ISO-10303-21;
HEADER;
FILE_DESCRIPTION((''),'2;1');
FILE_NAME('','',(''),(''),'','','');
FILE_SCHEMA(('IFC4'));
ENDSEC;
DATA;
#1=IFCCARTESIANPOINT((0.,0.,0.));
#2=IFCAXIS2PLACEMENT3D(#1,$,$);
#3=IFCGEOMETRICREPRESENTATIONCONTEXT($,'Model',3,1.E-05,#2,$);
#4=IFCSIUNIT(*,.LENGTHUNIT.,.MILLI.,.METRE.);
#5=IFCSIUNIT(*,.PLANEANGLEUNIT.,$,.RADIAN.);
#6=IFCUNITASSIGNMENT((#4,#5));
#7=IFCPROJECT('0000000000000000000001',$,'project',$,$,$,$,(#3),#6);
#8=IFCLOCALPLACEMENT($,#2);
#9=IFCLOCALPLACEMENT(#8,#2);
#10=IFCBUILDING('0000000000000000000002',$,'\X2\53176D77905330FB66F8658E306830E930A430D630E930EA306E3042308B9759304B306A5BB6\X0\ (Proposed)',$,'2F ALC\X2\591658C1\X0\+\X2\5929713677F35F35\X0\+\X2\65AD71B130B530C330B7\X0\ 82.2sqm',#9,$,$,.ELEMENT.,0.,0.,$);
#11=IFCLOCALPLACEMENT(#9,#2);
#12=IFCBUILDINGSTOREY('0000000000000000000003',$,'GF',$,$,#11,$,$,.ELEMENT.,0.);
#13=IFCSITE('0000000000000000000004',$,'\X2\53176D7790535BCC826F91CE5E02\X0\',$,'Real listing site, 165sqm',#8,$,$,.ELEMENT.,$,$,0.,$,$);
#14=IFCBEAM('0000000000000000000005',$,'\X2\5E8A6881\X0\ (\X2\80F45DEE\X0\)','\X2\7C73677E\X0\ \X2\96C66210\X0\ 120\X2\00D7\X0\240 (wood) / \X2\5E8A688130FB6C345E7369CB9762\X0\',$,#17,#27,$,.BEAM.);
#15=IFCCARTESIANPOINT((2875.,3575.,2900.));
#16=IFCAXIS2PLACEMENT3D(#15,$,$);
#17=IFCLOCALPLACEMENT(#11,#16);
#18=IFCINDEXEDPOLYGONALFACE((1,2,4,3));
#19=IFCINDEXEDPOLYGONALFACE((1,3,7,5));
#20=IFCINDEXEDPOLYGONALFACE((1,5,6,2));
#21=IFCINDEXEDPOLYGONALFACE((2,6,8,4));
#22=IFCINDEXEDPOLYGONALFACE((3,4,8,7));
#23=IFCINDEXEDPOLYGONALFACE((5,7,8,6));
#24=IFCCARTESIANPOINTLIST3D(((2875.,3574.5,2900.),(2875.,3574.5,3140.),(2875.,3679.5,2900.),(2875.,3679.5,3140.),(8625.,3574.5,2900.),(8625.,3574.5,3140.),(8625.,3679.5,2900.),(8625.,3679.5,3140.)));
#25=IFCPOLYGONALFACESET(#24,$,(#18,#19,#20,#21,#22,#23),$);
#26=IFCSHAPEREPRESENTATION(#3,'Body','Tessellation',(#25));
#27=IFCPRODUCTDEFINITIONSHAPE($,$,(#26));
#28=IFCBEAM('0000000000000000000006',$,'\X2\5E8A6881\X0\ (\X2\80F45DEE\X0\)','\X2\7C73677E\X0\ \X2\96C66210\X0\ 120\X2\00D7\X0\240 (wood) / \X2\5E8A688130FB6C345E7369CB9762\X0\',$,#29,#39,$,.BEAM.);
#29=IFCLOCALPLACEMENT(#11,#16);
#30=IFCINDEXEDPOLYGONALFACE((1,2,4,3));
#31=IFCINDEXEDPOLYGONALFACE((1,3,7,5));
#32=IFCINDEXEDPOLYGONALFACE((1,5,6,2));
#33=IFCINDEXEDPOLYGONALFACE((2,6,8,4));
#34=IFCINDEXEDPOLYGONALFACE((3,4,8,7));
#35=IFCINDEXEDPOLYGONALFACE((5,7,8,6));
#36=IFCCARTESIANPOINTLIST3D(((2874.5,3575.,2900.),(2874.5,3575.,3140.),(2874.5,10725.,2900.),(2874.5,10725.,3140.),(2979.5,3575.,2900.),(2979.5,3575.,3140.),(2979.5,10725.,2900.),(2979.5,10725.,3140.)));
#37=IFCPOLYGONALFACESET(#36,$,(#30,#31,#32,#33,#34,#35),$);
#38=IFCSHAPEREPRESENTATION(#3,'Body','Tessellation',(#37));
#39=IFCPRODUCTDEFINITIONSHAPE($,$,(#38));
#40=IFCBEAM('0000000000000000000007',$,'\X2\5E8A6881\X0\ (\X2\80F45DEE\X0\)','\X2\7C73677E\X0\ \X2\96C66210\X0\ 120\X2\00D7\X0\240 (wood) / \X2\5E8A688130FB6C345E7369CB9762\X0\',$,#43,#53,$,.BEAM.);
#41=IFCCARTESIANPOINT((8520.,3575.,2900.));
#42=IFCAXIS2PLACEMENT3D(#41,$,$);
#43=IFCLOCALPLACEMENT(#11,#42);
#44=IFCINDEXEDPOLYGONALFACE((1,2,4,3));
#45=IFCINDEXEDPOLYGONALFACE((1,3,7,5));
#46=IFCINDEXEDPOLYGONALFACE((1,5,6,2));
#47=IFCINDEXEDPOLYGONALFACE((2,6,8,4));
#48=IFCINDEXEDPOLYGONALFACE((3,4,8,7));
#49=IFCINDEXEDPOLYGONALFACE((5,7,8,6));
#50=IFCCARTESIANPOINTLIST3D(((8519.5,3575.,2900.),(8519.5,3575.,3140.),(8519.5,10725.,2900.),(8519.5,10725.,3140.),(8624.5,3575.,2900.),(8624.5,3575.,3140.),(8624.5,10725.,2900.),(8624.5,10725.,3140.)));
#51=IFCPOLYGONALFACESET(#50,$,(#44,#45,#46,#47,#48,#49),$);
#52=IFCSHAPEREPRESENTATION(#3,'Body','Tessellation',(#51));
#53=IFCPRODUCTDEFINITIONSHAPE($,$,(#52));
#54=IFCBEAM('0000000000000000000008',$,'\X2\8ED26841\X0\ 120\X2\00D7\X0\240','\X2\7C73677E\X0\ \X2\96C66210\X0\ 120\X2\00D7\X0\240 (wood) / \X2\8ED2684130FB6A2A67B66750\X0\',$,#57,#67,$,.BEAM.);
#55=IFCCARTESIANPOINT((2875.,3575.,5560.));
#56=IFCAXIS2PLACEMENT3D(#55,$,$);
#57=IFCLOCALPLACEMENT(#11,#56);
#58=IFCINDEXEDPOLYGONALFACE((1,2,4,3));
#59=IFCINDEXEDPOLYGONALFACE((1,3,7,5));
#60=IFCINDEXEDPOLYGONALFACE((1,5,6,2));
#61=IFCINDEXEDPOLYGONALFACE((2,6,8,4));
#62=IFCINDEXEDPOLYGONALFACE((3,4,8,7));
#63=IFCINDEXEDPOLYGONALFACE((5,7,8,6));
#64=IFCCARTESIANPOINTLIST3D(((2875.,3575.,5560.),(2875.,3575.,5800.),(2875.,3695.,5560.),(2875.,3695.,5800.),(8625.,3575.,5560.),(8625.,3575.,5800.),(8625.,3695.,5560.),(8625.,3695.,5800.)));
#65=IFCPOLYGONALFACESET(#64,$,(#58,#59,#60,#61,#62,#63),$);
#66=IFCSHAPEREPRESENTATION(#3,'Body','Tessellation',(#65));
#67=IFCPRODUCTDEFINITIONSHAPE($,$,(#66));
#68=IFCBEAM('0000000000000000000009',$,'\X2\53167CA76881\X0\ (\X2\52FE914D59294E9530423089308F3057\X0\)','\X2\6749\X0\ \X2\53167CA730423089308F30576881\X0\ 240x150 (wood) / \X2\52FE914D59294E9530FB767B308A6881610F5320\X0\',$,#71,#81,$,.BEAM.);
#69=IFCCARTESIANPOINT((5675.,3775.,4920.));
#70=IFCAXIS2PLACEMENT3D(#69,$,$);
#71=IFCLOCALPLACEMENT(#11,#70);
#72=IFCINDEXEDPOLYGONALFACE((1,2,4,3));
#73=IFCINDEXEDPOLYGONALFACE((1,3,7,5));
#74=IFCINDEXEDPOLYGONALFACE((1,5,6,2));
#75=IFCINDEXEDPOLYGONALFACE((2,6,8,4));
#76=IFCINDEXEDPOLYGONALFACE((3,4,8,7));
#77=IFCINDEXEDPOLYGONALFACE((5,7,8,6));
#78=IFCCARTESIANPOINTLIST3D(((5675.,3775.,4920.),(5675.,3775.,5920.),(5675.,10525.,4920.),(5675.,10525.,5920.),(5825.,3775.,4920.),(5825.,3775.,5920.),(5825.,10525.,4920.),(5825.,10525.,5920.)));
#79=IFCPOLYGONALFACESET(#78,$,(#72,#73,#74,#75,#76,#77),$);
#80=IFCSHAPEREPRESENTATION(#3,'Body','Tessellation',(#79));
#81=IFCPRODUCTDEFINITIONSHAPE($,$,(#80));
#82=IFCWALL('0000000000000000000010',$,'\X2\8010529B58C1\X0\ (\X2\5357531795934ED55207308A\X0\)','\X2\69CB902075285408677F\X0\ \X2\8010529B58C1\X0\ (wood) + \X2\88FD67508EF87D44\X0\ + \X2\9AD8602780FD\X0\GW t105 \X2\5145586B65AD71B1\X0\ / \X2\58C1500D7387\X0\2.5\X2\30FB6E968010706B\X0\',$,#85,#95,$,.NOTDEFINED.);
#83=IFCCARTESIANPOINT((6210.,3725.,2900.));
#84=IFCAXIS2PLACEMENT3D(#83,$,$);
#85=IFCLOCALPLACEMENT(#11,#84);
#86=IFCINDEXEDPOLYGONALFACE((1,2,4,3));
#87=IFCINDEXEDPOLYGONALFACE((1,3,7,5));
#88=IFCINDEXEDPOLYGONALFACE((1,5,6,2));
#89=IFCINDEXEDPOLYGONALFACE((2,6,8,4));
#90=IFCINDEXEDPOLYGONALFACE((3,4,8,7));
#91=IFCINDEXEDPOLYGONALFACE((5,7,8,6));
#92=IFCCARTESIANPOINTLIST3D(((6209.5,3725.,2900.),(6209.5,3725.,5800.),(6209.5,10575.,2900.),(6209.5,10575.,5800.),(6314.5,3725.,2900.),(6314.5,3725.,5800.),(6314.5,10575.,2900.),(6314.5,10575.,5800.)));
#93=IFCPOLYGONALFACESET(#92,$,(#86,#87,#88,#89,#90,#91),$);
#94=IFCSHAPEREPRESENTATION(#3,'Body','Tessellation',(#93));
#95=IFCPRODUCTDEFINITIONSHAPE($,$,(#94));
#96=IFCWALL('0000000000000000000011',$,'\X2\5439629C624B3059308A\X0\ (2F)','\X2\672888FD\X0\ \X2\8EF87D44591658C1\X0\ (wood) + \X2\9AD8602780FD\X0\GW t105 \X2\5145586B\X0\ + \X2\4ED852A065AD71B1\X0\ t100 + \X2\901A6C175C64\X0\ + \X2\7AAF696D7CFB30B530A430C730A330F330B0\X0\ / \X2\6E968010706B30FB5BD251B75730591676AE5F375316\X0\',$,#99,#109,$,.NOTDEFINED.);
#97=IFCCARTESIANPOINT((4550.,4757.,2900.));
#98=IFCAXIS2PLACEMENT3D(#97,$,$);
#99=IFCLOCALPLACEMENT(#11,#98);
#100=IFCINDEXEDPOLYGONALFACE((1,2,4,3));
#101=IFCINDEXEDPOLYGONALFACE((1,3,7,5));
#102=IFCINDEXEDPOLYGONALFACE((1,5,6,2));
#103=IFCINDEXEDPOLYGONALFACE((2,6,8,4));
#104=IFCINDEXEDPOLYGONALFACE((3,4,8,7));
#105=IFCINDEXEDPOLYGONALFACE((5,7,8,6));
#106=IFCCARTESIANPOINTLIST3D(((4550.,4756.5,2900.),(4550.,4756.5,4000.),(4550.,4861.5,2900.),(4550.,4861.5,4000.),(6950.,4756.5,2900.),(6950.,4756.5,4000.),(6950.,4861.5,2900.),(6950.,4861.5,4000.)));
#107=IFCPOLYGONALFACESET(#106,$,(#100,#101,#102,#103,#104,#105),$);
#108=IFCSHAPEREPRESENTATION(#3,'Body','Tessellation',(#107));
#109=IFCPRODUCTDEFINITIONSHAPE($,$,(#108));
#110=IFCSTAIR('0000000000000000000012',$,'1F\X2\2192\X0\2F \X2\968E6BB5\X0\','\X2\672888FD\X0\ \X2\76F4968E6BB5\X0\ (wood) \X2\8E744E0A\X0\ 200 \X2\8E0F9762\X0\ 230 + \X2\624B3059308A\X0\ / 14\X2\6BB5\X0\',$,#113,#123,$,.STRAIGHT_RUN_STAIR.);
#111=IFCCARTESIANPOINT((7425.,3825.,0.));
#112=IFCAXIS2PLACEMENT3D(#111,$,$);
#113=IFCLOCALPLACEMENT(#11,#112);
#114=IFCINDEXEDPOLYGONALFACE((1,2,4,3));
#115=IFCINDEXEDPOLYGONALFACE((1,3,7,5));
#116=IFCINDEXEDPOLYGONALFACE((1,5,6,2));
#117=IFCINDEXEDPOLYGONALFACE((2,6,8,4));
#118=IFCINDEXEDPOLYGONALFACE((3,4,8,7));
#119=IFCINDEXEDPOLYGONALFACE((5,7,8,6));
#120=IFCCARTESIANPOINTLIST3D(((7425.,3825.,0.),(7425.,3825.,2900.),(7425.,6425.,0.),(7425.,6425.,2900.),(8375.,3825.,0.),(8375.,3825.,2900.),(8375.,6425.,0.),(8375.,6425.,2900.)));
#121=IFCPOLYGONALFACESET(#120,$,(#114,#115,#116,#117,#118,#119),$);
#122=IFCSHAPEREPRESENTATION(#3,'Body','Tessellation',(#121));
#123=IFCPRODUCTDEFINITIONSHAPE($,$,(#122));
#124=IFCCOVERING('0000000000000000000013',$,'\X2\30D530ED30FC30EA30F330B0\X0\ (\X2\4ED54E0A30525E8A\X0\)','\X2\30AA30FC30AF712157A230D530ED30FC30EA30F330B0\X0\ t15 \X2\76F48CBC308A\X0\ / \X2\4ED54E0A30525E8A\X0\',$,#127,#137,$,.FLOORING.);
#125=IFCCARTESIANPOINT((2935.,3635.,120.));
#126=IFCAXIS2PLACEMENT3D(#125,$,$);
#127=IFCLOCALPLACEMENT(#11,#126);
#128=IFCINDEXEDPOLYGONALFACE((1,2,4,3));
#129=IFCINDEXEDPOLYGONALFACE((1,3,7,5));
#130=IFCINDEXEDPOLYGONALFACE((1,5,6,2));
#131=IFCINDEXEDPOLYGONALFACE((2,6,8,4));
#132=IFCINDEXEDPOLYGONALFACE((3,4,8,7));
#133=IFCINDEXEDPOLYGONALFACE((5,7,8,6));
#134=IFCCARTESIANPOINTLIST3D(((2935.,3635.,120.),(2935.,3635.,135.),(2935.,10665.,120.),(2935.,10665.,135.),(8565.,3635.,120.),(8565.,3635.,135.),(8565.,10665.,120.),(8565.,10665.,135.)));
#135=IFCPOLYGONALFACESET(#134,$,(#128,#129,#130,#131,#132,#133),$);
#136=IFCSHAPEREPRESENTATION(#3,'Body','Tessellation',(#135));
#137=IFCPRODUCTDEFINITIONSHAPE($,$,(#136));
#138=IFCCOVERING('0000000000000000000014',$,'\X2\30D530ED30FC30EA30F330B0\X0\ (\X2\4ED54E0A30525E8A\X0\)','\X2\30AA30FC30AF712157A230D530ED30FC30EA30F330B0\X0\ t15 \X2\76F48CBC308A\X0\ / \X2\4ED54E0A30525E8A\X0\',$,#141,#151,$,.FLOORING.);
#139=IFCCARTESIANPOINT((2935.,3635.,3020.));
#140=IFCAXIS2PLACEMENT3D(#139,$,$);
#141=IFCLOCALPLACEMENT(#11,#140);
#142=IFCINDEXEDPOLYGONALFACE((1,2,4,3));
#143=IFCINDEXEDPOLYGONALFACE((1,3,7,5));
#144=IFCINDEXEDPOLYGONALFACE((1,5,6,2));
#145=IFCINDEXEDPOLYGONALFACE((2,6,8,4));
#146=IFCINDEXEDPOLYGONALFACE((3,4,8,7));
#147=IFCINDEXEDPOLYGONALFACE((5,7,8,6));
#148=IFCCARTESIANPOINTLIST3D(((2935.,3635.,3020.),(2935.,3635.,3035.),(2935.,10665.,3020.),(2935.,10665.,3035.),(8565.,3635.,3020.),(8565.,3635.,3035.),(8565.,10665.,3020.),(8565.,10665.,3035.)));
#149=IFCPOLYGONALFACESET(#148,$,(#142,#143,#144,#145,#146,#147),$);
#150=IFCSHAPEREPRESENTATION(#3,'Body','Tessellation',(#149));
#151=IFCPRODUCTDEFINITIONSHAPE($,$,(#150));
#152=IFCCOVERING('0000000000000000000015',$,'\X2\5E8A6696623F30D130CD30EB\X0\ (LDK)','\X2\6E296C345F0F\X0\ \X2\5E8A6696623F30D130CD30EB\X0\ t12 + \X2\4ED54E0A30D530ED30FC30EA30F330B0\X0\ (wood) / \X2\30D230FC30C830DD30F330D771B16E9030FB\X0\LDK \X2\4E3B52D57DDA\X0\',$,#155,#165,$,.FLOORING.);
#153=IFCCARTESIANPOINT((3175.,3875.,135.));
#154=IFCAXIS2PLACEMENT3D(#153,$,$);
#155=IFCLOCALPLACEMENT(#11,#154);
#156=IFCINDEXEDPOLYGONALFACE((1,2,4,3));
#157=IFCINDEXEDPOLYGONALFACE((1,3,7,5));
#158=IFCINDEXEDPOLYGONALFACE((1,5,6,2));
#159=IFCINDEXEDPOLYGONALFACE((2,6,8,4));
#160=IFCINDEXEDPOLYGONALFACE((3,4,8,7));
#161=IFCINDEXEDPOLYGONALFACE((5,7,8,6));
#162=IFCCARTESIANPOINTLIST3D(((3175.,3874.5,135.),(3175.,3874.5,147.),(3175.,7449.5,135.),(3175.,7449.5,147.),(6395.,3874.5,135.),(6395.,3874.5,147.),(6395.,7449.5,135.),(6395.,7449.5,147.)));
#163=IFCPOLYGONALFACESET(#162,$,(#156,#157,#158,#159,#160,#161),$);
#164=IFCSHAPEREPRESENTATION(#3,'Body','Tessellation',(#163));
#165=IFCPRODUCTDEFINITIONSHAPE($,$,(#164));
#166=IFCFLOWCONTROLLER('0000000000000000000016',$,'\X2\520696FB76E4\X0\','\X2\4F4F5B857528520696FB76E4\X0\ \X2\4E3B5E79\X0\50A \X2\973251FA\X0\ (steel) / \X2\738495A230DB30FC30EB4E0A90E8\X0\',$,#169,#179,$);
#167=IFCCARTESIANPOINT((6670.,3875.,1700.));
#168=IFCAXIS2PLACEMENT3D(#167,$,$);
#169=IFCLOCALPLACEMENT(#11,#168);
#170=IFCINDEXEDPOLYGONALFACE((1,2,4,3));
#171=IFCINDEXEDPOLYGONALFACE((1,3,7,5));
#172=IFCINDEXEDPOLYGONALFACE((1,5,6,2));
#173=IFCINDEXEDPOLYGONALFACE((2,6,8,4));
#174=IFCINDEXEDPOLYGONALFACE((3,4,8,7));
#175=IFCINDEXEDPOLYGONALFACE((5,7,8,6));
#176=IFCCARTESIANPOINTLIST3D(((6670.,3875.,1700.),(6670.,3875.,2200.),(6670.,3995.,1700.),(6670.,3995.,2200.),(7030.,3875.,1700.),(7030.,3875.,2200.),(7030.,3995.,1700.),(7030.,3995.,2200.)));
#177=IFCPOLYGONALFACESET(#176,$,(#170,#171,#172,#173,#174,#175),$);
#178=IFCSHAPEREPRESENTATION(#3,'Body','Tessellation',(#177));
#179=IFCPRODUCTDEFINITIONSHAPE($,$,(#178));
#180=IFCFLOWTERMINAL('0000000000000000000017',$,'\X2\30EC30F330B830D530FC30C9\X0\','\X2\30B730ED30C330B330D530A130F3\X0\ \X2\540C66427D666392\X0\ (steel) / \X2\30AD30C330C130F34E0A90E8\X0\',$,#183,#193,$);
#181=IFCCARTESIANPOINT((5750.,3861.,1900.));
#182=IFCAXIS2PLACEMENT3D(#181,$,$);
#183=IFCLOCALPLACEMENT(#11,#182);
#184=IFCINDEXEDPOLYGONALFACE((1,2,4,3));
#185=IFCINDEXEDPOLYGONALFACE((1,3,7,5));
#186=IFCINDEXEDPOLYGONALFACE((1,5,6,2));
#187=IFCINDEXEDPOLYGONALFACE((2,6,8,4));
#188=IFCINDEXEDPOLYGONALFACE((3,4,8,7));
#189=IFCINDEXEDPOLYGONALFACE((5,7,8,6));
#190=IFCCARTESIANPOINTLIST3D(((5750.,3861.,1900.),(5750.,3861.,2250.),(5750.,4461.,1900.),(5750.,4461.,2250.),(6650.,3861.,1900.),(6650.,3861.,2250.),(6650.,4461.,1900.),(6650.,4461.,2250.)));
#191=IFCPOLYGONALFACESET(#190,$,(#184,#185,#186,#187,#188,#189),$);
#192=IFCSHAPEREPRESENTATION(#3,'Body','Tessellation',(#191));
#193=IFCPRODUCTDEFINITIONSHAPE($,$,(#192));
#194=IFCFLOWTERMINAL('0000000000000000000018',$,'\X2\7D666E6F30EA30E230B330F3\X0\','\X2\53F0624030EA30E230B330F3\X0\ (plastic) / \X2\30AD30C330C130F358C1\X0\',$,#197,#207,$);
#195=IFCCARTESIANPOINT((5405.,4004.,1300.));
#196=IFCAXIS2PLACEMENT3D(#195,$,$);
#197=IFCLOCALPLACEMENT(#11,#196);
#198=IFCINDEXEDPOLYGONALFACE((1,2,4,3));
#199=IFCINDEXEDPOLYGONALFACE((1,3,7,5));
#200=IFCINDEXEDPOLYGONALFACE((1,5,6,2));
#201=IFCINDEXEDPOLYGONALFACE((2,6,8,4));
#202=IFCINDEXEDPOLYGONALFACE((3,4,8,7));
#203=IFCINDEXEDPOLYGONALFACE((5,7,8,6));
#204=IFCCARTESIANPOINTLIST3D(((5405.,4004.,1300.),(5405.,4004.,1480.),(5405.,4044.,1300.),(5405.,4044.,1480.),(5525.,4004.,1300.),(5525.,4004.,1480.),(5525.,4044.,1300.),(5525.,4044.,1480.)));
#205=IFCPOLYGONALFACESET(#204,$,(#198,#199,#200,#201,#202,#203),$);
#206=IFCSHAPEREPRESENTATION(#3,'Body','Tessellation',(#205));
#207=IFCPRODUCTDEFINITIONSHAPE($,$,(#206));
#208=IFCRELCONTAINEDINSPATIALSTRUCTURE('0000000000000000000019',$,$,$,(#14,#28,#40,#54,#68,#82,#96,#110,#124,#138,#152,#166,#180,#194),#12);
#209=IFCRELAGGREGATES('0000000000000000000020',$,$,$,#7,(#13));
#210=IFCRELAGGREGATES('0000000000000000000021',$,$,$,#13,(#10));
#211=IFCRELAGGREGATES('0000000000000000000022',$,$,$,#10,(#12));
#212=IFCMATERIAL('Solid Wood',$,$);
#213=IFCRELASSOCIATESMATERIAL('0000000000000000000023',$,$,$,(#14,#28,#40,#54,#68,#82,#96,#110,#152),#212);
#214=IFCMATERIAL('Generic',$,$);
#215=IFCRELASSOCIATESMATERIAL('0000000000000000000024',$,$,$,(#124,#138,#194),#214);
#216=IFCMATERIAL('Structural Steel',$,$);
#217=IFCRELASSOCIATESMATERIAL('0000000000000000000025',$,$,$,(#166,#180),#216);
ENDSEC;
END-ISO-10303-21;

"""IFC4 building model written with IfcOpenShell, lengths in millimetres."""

from ifc_helpers import new_model, si_unit, frame, frame_2d, origin, place, context, project, spatial, rectangle, extrude, material, element, save


model = new_model("IFC4")

# Units and contexts
model_context = context("Model", 3, precision=1e-05, world=origin())
ifc_project = project(units=[si_unit("LENGTHUNIT", "METRE", prefix="MILLI"), si_unit("PLANEANGLEUNIT", "RADIAN")], contexts=[model_context])

# Site, building, storey
site_placement = place(None, origin())
site = spatial("IfcSite", under=ifc_project, at=site_placement, Name="北海道富良野市", ObjectType="Real listing site, 165sqm", CompositionType="ELEMENT", RefElevation=0.0)
building_placement = place(site_placement, origin())
building = spatial("IfcBuilding", under=site, at=building_placement, Name="北海道・書斎とライブラリのある静かな家 (Proposed)", ObjectType="2F ALC外壁+天然石張+断熱サッシ 82.2sqm", CompositionType="ELEMENT", ElevationOfRefHeight=0.0, ElevationOfTerrain=0.0)
storey_placement = place(building_placement, origin())
storey = spatial("IfcBuildingStorey", under=building, at=storey_placement, Name="GF", CompositionType="ELEMENT", Elevation=0.0)

# Beams
ifc_material_1 = material(Name="Solid Wood")
beam_1_placement = place(storey_placement, frame((2875.0, 3575.0, 2900.0)))
element("IfcBeam", 1, at=beam_1_placement, inside=storey, material=ifc_material_1, Name="床梁 (胴差)", Description="米松 集成 120×240 (wood) / 床梁・水平構面", PredefinedType="BEAM", context=model_context, shape_type="SweptSolid", body=[
    extrude(rectangle(XDim=5750.0, YDim=105.0, at=frame_2d((2875.0, 52.0))), frame((2875.0, 3575.0, 2900.0)), (0.0, 0.0, 1.0), 240.0),
])
beam_2_placement = place(storey_placement, frame((2875.0, 3575.0, 2900.0)))
element("IfcBeam", 2, at=beam_2_placement, inside=storey, material=ifc_material_1, Name="床梁 (胴差)", Description="米松 集成 120×240 (wood) / 床梁・水平構面", PredefinedType="BEAM", context=model_context, shape_type="SweptSolid", body=[
    extrude(rectangle(XDim=105.0, YDim=7150.0, at=frame_2d((52.0, 3575.0))), frame((2875.0, 3575.0, 2900.0)), (0.0, 0.0, 1.0), 240.0),
])
beam_3_placement = place(storey_placement, frame((8520.0, 3575.0, 2900.0)))
element("IfcBeam", 3, at=beam_3_placement, inside=storey, material=ifc_material_1, Name="床梁 (胴差)", Description="米松 集成 120×240 (wood) / 床梁・水平構面", PredefinedType="BEAM", context=model_context, shape_type="SweptSolid", body=[
    extrude(rectangle(XDim=105.0, YDim=7150.0, at=frame_2d((52.0, 3575.0))), frame((8520.0, 3575.0, 2900.0)), (0.0, 0.0, 1.0), 240.0),
])
beam_4_placement = place(storey_placement, frame((2875.0, 3575.0, 5560.0)))
element("IfcBeam", 4, at=beam_4_placement, inside=storey, material=ifc_material_1, Name="軒桁 120×240", Description="米松 集成 120×240 (wood) / 軒桁・横架材", PredefinedType="BEAM", context=model_context, shape_type="SweptSolid", body=[
    extrude(rectangle(XDim=5750.0, YDim=120.0, at=frame_2d((2875.0, 60.0))), frame((2875.0, 3575.0, 5560.0)), (0.0, 0.0, 1.0), 240.0),
])
beam_5_placement = place(storey_placement, frame((5675.0, 3775.0, 4920.0)))
element("IfcBeam", 5, at=beam_5_placement, inside=storey, material=ifc_material_1, Name="化粧梁 (勾配天井あらわし)", Description="杉 化粧あらわし梁 240x150 (wood) / 勾配天井・登り梁意匠", PredefinedType="BEAM", context=model_context, shape_type="SweptSolid", body=[
    extrude(rectangle(XDim=150.0, YDim=6750.0, at=frame_2d((75.0, 3375.0))), frame((5675.0, 3775.0, 4920.0)), (0.0, 0.0, 1.0), 1000.0),
])

# Walls
wall_1_placement = place(storey_placement, frame((6210.0, 3725.0, 2900.0)))
element("IfcWall", 6, at=wall_1_placement, inside=storey, material=ifc_material_1, Name="耐力壁 (南北間仕切り)", Description="構造用合板 耐力壁 (wood) + 製材軸組 + 高性能GW t105 充填断熱 / 壁倍率2.5・準耐火", PredefinedType="NOTDEFINED", context=model_context, shape_type="SweptSolid", body=[
    extrude(rectangle(XDim=105.0, YDim=6850.0, at=frame_2d((52.0, 3425.0))), frame((6210.0, 3725.0, 2900.0)), (0.0, 0.0, 1.0), 2900.0),
])
wall_2_placement = place(storey_placement, frame((4550.0, 4757.0, 2900.0)))
element("IfcWall", 7, at=wall_2_placement, inside=storey, material=ifc_material_1, Name="吹抜手すり (2F)", Description="木製 軸組外壁 (wood) + 高性能GW t105 充填 + 付加断熱 t100 + 通気層 + 窯業系サイディング / 準耐火・寒冷地外皮強化", PredefinedType="NOTDEFINED", context=model_context, shape_type="SweptSolid", body=[
    extrude(rectangle(XDim=2400.0, YDim=105.0, at=frame_2d((1200.0, 52.0))), frame((4550.0, 4757.0, 2900.0)), (0.0, 0.0, 1.0), 1100.0),
])

# Stair
stair_placement = place(storey_placement, frame((7425.0, 3825.0, 0.0)))
element("IfcStair", 8, at=stair_placement, inside=storey, material=ifc_material_1, Name="1F→2F 階段", Description="木製 直階段 (wood) 蹴上 200 踏面 230 + 手すり / 14段", PredefinedType="STRAIGHT_RUN_STAIR", context=model_context, shape_type="SweptSolid", body=[
    extrude(rectangle(XDim=950.0, YDim=2600.0, at=frame_2d((475.0, 1300.0))), frame((7425.0, 3825.0, 0.0)), (0.0, 0.0, 1.0), 2900.0),
])

# Coverings
ifc_material_2 = material(Name="Generic")
covering_1_placement = place(storey_placement, frame((2935.0, 3635.0, 120.0)))
element("IfcCovering", 9, at=covering_1_placement, inside=storey, material=ifc_material_2, Name="フローリング (仕上げ床)", Description="オーク無垢フローリング t15 直貼り / 仕上げ床", PredefinedType="FLOORING", context=model_context, shape_type="SweptSolid", body=[
    extrude(rectangle(XDim=5630.0, YDim=7030.0, at=frame_2d((2815.0, 3515.0))), frame((2935.0, 3635.0, 120.0)), (0.0, 0.0, 1.0), 15.0),
])
covering_2_placement = place(storey_placement, frame((2935.0, 3635.0, 3020.0)))
element("IfcCovering", 10, at=covering_2_placement, inside=storey, material=ifc_material_2, Name="フローリング (仕上げ床)", Description="オーク無垢フローリング t15 直貼り / 仕上げ床", PredefinedType="FLOORING", context=model_context, shape_type="SweptSolid", body=[
    extrude(rectangle(XDim=5630.0, YDim=7030.0, at=frame_2d((2815.0, 3515.0))), frame((2935.0, 3635.0, 3020.0)), (0.0, 0.0, 1.0), 15.0),
])
covering_3_placement = place(storey_placement, frame((3175.0, 3875.0, 135.0)))
element("IfcCovering", 11, at=covering_3_placement, inside=storey, material=ifc_material_1, Name="床暖房パネル (LDK)", Description="温水式 床暖房パネル t12 + 仕上フローリング (wood) / ヒートポンプ熱源・LDK 主動線", PredefinedType="FLOORING", context=model_context, shape_type="SweptSolid", body=[
    extrude(rectangle(XDim=3220.0, YDim=3575.0, at=frame_2d((1610.0, 1787.0))), frame((3175.0, 3875.0, 135.0)), (0.0, 0.0, 1.0), 12.0),
])

# Flow controller
ifc_material_3 = material(Name="Structural Steel")
flow_controller_placement = place(storey_placement, frame((6670.0, 3875.0, 1700.0)))
element("IfcFlowController", 12, at=flow_controller_placement, inside=storey, material=ifc_material_3, Name="分電盤", Description="住宅用分電盤 主幹50A 露出 (steel) / 玄関ホール上部", context=model_context, shape_type="SweptSolid", body=[
    extrude(rectangle(XDim=360.0, YDim=120.0, at=frame_2d((180.0, 60.0))), frame((6670.0, 3875.0, 1700.0)), (0.0, 0.0, 1.0), 500.0),
])

# Flow terminals
flow_terminal_1_placement = place(storey_placement, frame((5750.0, 3861.0, 1900.0)))
element("IfcFlowTerminal", 13, at=flow_terminal_1_placement, inside=storey, material=ifc_material_3, Name="レンジフード", Description="シロッコファン 同時給排 (steel) / キッチン上部", context=model_context, shape_type="SweptSolid", body=[
    extrude(rectangle(XDim=900.0, YDim=600.0, at=frame_2d((450.0, 300.0))), frame((5750.0, 3861.0, 1900.0)), (0.0, 0.0, 1.0), 350.0),
])
flow_terminal_2_placement = place(storey_placement, frame((5405.0, 4004.0, 1300.0)))
element("IfcFlowTerminal", 14, at=flow_terminal_2_placement, inside=storey, material=ifc_material_2, Name="給湯リモコン", Description="台所リモコン (plastic) / キッチン壁", context=model_context, shape_type="SweptSolid", body=[
    extrude(rectangle(XDim=120.0, YDim=40.0, at=frame_2d((60.0, 20.0))), frame((5405.0, 4004.0, 1300.0)), (0.0, 0.0, 1.0), 180.0),
])

save(model, "model.ifc")
